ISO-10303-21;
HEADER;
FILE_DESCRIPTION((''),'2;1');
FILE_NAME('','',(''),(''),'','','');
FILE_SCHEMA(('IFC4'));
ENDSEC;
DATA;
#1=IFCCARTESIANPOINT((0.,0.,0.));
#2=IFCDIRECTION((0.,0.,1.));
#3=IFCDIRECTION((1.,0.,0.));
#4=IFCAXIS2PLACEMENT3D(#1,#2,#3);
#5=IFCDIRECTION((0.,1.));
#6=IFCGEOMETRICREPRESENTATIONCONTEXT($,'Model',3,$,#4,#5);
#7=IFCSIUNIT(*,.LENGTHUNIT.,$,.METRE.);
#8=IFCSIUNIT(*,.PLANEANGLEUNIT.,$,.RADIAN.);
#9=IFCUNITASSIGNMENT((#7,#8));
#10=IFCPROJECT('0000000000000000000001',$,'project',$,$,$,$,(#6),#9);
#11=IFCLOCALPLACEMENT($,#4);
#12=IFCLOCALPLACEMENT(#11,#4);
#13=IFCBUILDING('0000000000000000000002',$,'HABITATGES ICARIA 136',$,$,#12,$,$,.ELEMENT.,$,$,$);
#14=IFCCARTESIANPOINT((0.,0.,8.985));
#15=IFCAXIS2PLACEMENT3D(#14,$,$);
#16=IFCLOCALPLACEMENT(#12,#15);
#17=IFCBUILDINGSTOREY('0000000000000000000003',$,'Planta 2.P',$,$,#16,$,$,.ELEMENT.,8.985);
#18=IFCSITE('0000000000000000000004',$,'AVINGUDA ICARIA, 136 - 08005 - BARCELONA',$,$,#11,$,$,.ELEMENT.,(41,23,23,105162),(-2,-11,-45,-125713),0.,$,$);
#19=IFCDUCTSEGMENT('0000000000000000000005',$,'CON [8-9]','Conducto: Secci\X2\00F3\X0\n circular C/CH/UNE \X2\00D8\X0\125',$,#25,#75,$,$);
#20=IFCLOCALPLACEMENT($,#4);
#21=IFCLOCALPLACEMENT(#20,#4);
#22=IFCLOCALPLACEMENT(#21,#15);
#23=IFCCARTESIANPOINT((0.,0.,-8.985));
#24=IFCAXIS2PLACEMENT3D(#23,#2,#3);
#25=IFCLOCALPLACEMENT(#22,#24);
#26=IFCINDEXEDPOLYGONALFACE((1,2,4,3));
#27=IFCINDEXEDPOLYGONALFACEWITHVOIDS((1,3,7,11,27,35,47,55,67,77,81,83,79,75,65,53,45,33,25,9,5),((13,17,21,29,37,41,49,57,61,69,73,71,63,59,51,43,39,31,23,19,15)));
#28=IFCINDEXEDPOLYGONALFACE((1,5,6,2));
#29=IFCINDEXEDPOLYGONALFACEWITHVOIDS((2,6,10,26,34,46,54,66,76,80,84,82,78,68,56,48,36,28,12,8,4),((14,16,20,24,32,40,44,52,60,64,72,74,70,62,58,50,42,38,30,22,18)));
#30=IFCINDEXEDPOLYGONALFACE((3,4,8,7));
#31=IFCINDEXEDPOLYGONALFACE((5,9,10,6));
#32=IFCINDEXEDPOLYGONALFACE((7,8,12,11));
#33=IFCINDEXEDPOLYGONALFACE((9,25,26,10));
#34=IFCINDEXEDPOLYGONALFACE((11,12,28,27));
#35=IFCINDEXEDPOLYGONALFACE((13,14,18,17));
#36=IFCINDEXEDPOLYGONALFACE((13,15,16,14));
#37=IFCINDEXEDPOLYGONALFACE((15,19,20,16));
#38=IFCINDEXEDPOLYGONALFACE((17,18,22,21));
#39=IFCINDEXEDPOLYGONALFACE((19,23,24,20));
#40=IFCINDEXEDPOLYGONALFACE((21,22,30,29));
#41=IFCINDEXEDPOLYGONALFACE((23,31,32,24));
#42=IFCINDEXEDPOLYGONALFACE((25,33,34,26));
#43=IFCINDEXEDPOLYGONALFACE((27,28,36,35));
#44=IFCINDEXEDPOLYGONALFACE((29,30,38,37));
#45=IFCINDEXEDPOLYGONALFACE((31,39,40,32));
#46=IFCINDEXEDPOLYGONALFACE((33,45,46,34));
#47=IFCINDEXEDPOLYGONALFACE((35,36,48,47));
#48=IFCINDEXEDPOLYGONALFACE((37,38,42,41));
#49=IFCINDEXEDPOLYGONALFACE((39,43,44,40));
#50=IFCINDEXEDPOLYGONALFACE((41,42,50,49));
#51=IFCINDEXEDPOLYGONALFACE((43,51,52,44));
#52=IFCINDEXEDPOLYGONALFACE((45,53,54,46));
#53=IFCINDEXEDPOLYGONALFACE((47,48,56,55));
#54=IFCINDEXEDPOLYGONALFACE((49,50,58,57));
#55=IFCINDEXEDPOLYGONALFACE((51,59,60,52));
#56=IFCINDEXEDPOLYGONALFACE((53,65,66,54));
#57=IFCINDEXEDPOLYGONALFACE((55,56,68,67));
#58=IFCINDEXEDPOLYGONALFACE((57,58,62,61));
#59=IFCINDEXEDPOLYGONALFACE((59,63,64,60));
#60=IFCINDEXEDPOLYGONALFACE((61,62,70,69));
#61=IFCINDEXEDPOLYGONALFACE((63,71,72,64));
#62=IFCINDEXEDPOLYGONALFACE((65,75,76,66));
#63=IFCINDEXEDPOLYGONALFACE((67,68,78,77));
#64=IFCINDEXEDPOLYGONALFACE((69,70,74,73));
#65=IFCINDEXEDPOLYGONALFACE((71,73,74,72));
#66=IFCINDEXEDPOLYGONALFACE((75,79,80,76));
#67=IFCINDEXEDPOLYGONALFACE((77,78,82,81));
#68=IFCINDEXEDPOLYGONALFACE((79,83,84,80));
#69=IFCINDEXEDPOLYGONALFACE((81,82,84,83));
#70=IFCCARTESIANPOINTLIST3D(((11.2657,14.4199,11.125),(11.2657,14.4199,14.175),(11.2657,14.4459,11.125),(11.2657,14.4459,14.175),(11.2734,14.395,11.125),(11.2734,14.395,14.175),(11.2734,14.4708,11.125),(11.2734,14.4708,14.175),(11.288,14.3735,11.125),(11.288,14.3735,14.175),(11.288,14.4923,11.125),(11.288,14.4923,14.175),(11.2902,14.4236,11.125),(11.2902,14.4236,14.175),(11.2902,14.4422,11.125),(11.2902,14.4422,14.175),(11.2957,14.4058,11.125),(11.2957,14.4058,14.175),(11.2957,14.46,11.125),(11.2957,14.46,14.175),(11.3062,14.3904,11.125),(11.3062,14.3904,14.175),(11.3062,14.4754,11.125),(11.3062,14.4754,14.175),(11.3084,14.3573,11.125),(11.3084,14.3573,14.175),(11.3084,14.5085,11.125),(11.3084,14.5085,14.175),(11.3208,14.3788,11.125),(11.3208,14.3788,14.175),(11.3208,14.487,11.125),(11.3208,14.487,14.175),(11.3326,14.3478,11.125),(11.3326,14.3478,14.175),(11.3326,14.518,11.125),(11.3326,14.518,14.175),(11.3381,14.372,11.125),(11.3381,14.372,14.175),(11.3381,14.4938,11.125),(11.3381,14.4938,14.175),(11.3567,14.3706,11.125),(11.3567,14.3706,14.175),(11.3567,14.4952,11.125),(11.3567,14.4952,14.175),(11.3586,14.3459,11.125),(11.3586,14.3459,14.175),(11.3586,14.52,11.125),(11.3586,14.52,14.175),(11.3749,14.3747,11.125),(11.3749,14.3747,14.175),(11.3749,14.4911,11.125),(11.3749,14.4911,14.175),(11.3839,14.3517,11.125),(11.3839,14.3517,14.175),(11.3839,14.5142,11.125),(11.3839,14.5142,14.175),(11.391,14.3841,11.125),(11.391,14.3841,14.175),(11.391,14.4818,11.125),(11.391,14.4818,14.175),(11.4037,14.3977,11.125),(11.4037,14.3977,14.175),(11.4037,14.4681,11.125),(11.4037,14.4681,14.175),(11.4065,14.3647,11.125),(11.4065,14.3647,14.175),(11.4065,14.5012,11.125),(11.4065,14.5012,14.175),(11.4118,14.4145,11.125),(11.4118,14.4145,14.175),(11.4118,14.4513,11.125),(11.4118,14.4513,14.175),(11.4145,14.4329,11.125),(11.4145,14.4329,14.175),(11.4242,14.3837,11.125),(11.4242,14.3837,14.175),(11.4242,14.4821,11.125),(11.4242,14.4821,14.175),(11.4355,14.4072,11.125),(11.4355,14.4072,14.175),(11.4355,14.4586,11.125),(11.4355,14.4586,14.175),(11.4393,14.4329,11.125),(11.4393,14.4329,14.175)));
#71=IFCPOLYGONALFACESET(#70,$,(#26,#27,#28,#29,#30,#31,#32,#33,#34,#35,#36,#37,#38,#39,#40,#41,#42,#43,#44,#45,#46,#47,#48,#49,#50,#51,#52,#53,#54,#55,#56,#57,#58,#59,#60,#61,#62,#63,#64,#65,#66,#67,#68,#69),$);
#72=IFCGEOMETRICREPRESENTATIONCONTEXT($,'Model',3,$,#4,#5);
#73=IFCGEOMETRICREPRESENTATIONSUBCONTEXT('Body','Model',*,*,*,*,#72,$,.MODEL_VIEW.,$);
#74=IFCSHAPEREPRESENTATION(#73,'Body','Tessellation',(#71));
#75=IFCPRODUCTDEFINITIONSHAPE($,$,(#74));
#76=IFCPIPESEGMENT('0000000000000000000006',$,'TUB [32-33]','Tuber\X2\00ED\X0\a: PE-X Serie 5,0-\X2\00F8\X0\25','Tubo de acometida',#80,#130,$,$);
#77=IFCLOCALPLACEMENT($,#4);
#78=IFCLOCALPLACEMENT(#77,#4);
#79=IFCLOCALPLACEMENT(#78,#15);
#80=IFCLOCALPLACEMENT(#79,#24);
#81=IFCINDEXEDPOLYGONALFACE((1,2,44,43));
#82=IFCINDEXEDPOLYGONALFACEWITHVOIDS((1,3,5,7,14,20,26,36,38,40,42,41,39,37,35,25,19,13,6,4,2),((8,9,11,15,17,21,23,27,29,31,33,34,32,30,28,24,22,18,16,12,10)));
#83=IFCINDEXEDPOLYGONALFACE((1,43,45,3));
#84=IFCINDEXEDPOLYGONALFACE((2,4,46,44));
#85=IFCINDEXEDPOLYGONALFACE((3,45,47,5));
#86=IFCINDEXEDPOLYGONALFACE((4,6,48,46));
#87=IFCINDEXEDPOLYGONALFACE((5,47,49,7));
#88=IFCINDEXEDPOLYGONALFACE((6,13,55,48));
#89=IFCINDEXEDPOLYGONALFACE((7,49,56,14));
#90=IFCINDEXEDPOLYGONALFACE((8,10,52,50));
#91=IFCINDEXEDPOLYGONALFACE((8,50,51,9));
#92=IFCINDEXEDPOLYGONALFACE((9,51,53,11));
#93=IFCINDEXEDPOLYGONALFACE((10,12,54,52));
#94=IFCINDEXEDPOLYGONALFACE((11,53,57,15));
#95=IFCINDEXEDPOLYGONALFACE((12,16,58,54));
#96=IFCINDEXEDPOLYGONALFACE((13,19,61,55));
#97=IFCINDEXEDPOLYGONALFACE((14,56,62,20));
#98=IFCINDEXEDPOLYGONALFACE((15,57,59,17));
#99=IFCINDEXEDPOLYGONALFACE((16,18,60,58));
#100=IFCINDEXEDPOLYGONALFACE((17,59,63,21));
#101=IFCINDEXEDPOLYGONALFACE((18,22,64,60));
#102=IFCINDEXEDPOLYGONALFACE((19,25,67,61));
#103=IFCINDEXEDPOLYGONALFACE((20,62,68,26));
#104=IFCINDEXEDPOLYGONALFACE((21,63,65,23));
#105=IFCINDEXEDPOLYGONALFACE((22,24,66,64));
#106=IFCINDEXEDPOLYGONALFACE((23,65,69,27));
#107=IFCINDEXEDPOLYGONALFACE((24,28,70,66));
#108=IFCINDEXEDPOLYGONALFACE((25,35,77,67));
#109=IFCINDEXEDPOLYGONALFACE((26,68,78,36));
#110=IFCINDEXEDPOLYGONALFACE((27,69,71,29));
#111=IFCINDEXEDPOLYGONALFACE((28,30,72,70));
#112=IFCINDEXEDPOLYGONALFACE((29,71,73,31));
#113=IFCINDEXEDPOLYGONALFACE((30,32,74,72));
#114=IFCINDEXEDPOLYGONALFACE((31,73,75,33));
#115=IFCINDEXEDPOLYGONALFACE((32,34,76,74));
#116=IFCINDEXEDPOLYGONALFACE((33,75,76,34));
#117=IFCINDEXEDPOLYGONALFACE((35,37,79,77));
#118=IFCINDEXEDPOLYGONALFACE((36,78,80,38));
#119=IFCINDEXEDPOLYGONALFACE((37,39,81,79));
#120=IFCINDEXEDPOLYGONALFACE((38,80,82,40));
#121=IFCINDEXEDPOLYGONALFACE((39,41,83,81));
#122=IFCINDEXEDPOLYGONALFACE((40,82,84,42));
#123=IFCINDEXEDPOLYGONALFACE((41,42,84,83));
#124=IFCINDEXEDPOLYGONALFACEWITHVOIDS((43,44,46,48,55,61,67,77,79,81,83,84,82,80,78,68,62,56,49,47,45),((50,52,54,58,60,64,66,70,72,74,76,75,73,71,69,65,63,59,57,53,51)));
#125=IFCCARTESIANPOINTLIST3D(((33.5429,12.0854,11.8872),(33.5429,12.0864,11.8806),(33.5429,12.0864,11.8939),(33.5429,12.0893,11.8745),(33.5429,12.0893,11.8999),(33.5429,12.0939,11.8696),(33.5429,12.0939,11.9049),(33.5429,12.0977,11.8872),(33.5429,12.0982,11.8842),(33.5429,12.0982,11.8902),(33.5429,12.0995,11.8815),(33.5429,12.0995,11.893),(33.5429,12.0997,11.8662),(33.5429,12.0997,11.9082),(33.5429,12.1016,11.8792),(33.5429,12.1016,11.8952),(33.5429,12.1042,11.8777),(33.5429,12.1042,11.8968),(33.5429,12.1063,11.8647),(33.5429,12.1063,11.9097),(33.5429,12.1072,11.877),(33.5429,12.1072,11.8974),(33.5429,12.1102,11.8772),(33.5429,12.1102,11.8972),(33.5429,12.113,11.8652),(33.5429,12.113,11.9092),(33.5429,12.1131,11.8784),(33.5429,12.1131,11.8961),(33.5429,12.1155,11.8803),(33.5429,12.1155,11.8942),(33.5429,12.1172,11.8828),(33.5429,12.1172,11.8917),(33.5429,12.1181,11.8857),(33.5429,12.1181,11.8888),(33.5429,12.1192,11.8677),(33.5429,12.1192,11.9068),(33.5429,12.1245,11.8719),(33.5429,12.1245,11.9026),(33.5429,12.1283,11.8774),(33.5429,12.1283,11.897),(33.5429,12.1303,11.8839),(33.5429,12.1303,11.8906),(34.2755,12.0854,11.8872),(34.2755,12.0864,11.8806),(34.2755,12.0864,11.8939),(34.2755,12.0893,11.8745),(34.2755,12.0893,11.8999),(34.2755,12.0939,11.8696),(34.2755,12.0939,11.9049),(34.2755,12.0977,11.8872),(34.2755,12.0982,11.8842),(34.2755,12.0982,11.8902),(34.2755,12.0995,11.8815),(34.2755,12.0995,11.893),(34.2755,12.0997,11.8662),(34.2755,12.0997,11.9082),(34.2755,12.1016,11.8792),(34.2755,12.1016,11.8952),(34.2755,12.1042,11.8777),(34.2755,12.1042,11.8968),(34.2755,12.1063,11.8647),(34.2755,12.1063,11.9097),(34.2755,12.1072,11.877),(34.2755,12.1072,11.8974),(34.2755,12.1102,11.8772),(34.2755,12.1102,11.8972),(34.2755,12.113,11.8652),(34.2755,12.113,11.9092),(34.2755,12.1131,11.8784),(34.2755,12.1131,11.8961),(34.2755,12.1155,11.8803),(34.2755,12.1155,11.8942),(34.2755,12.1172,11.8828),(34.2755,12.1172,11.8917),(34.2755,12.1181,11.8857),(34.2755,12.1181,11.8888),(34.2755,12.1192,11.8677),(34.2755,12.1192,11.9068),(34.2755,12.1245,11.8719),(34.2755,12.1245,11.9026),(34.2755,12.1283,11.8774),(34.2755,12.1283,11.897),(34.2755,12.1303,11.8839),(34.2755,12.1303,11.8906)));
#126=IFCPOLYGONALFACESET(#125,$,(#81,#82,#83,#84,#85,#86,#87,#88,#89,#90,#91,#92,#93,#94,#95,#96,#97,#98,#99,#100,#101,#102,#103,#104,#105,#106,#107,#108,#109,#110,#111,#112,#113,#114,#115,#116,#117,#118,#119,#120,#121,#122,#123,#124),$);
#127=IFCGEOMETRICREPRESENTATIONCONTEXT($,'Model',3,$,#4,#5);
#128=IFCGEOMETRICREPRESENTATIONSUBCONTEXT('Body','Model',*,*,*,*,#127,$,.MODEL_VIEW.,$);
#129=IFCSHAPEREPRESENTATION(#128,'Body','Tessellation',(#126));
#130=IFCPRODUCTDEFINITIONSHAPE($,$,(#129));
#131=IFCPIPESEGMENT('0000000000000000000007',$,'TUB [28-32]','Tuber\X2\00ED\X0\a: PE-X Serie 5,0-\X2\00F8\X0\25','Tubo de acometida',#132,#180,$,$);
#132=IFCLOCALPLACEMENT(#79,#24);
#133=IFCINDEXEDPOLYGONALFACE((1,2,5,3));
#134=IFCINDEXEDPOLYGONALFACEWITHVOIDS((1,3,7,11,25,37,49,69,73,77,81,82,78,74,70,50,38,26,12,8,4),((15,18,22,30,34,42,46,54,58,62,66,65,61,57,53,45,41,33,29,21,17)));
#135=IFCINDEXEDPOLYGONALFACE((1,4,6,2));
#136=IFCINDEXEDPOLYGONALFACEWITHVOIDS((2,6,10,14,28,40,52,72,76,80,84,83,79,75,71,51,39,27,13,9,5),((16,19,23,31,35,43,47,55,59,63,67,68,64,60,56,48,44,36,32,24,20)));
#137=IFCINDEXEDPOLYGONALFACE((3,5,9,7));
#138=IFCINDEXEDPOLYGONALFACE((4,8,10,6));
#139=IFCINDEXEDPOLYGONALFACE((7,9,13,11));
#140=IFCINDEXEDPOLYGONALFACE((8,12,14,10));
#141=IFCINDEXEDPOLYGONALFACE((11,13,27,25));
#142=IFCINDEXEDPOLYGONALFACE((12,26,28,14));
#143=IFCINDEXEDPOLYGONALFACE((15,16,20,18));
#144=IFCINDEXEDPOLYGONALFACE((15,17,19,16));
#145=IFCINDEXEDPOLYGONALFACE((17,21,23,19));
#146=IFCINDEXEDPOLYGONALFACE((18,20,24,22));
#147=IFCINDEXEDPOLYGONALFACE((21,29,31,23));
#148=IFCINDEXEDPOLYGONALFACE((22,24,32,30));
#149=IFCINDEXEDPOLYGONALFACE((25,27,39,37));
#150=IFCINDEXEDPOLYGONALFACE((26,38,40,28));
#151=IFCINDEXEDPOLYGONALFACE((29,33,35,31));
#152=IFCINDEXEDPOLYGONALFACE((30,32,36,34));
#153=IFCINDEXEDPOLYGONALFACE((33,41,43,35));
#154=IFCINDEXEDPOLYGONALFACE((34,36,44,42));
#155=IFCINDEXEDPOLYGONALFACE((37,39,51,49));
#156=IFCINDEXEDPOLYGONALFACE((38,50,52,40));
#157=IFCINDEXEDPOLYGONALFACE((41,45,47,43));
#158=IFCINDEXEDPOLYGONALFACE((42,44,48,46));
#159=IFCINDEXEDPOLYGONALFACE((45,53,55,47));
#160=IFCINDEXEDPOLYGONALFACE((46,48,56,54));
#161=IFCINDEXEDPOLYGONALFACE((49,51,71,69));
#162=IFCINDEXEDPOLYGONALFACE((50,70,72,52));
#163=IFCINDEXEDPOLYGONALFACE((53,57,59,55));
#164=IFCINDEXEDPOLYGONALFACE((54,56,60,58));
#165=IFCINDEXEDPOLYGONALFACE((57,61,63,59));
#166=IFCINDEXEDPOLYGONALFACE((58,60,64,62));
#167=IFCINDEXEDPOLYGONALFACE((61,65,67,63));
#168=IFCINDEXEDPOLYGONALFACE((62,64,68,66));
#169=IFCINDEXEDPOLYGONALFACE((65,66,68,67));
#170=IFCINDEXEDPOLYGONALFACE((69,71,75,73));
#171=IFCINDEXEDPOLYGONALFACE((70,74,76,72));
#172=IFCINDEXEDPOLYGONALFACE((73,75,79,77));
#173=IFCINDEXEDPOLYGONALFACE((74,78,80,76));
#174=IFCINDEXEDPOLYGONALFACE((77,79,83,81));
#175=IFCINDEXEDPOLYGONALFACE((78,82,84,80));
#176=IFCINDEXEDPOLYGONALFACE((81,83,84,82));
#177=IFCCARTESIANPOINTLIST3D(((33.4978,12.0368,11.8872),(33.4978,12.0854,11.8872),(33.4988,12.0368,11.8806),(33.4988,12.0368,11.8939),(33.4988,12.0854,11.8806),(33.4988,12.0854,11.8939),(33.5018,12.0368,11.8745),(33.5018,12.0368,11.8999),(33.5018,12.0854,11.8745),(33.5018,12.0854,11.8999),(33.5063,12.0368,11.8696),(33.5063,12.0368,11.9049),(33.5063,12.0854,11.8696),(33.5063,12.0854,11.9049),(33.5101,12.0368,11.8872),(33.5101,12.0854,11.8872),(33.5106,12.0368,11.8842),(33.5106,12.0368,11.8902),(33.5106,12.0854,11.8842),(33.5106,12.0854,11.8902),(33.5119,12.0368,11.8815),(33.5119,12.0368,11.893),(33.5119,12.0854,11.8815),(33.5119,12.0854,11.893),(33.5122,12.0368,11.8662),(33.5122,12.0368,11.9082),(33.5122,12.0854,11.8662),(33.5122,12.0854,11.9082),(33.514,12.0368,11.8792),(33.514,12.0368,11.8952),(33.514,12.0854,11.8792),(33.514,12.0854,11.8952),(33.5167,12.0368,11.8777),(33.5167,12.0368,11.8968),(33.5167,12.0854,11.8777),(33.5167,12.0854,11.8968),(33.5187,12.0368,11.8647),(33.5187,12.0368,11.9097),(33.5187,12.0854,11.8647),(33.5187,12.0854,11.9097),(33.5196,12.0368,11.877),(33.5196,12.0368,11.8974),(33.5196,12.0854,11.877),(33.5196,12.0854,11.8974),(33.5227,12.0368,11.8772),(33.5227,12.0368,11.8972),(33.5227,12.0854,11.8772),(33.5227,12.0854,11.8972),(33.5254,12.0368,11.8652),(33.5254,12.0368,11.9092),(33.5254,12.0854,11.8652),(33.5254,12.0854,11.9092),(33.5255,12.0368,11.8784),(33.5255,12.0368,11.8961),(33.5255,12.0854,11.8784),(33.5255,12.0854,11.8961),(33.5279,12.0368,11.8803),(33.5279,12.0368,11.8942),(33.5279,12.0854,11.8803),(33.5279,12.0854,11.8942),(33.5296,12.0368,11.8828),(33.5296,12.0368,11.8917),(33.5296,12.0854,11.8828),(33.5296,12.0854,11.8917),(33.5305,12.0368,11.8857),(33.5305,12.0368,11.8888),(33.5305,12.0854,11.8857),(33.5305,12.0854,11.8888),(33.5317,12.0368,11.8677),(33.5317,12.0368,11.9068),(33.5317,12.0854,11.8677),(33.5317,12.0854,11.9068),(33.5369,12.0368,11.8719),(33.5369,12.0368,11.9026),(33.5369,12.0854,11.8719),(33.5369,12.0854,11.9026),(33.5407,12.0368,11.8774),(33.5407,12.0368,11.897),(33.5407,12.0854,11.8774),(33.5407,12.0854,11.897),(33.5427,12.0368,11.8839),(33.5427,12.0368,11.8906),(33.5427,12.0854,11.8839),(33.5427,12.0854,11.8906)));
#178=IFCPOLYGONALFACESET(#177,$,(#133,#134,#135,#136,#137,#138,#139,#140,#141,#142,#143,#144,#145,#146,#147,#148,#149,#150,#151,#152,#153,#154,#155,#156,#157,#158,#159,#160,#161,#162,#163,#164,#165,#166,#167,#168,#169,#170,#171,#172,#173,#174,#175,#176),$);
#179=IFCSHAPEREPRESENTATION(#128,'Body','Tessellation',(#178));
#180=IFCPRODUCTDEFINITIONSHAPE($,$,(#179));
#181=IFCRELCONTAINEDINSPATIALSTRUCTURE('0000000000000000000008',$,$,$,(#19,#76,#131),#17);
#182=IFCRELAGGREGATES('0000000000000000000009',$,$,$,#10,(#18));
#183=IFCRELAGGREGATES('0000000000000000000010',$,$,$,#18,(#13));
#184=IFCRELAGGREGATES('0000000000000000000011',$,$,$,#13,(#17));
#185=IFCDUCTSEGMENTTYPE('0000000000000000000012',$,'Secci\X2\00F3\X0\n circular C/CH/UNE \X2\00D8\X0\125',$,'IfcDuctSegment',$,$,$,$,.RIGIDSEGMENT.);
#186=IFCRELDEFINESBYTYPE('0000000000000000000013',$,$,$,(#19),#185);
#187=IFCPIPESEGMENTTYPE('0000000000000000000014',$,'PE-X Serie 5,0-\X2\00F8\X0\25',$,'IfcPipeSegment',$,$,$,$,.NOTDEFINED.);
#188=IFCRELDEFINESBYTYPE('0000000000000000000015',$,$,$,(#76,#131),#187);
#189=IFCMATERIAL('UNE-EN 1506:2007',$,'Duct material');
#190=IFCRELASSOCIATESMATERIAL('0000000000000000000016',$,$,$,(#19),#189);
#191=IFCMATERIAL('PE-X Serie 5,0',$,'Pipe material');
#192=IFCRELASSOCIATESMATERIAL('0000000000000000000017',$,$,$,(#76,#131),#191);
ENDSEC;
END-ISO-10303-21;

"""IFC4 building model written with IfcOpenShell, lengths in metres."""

from ifc_helpers import new_model, si_unit, direction, frame, origin_with_axes, origin_2d_with_axis, place, context, subcontext, project, spatial, hollow_circle, extrude, material, type_object, element, save


model = new_model("IFC4")

# Units and contexts
model_context_1 = context("Model", 3, world=origin_with_axes(), true_north=direction((0.0, 1.0)))
model_context_2 = context("Model", 3, world=origin_with_axes(), true_north=direction((0.0, 1.0)))
model_context_3 = context("Model", 3, world=origin_with_axes(), true_north=direction((0.0, 1.0)))
body_context_1 = subcontext(model_context_2, "Body", "Model", "MODEL_VIEW")
body_context_2 = subcontext(model_context_3, "Body", "Model", "MODEL_VIEW")
ifc_project = project(units=[si_unit("LENGTHUNIT", "METRE"), si_unit("PLANEANGLEUNIT", "RADIAN")], contexts=[model_context_1])

# Site, building, storey
site_placement = place(None, origin_with_axes())
site = spatial("IfcSite", under=ifc_project, at=site_placement, Name="AVINGUDA ICARIA, 136 - 08005 - BARCELONA", CompositionType="ELEMENT", RefLatitude=(41, 23, 23, 105162), RefLongitude=(-2, -11, -45, -125713), RefElevation=0.0)
building_placement = place(site_placement, origin_with_axes())
building = spatial("IfcBuilding", under=site, at=building_placement, Name="HABITATGES ICARIA 136", CompositionType="ELEMENT")
storey_placement = place(building_placement, frame((0.0, 0.0, 8.985)))
storey = spatial("IfcBuildingStorey", under=building, at=storey_placement, Name="Planta 2.P", CompositionType="ELEMENT", Elevation=8.985)

# Duct segment
ifc_material_1 = material(Name="UNE-EN 1506:2007", Category="Duct material")
duct_segment_type = type_object("IfcDuctSegmentType", Name="Sección circular C/CH/UNE Ø125", ApplicableOccurrence="IfcDuctSegment", PredefinedType="RIGIDSEGMENT")
placement_1 = place(None, origin_with_axes())
placement_2 = place(placement_1, origin_with_axes())
placement_3 = place(placement_2, frame((0.0, 0.0, 8.985)))
duct_segment_placement = place(placement_3, frame((0.0, 0.0, -8.985), z_axis=(0.0, 0.0, 1.0), x_axis=(1.0, 0.0, 0.0)))
element("IfcDuctSegment", 1, at=duct_segment_placement, inside=storey, type_object=duct_segment_type, material=ifc_material_1, Name="CON [8-9]", Description="Conducto: Sección circular C/CH/UNE Ø125", context=body_context_1, shape_type="SweptSolid", body=[
    extrude(hollow_circle(Radius=0.0873, WallThickness=0.0248, at=origin_2d_with_axis()), frame((11.352, 14.4329, 14.175), z_axis=(0.0, 0.0, -1.0), x_axis=(1.0, 0.0, 0.0)), (0.0, 0.0, 1.0), 3.05),
])

# Pipe segments
ifc_material_2 = material(Name="PE-X Serie 5,0", Category="Pipe material")
pipe_segment_type = type_object("IfcPipeSegmentType", Name="PE-X Serie 5,0-ø25", ApplicableOccurrence="IfcPipeSegment", PredefinedType="NOTDEFINED")
placement_4 = place(None, origin_with_axes())
placement_5 = place(placement_4, origin_with_axes())
placement_6 = place(placement_5, frame((0.0, 0.0, 8.985)))
pipe_segment_1_placement = place(placement_6, frame((0.0, 0.0, -8.985), z_axis=(0.0, 0.0, 1.0), x_axis=(1.0, 0.0, 0.0)))
element("IfcPipeSegment", 2, at=pipe_segment_1_placement, inside=storey, type_object=pipe_segment_type, material=ifc_material_2, Name="TUB [32-33]", Description="Tubería: PE-X Serie 5,0-ø25", ObjectType="Tubo de acometida", context=body_context_2, shape_type="SweptSolid", body=[
    extrude(hollow_circle(Radius=0.0226, WallThickness=0.0123, at=origin_2d_with_axis()), frame((34.2755, 12.108, 11.8872), z_axis=(-1.0, 0.0, 0.0), x_axis=(0.0, -1.0, 0.0)), (0.0, 0.0, 1.0), 0.7325),
])
pipe_segment_2_placement = place(placement_6, frame((0.0, 0.0, -8.985), z_axis=(0.0, 0.0, 1.0), x_axis=(1.0, 0.0, 0.0)))
element("IfcPipeSegment", 3, at=pipe_segment_2_placement, inside=storey, type_object=pipe_segment_type, material=ifc_material_2, Name="TUB [28-32]", Description="Tubería: PE-X Serie 5,0-ø25", ObjectType="Tubo de acometida", context=body_context_2, shape_type="SweptSolid", body=[
    extrude(hollow_circle(Radius=0.0226, WallThickness=0.0123, at=origin_2d_with_axis()), frame((33.5204, 12.0368, 11.8872), z_axis=(0.0, 1.0, 0.0), x_axis=(-1.0, 0.0, 0.0)), (0.0, 0.0, 1.0), 0.0486),
])

save(model, "model.ifc")
